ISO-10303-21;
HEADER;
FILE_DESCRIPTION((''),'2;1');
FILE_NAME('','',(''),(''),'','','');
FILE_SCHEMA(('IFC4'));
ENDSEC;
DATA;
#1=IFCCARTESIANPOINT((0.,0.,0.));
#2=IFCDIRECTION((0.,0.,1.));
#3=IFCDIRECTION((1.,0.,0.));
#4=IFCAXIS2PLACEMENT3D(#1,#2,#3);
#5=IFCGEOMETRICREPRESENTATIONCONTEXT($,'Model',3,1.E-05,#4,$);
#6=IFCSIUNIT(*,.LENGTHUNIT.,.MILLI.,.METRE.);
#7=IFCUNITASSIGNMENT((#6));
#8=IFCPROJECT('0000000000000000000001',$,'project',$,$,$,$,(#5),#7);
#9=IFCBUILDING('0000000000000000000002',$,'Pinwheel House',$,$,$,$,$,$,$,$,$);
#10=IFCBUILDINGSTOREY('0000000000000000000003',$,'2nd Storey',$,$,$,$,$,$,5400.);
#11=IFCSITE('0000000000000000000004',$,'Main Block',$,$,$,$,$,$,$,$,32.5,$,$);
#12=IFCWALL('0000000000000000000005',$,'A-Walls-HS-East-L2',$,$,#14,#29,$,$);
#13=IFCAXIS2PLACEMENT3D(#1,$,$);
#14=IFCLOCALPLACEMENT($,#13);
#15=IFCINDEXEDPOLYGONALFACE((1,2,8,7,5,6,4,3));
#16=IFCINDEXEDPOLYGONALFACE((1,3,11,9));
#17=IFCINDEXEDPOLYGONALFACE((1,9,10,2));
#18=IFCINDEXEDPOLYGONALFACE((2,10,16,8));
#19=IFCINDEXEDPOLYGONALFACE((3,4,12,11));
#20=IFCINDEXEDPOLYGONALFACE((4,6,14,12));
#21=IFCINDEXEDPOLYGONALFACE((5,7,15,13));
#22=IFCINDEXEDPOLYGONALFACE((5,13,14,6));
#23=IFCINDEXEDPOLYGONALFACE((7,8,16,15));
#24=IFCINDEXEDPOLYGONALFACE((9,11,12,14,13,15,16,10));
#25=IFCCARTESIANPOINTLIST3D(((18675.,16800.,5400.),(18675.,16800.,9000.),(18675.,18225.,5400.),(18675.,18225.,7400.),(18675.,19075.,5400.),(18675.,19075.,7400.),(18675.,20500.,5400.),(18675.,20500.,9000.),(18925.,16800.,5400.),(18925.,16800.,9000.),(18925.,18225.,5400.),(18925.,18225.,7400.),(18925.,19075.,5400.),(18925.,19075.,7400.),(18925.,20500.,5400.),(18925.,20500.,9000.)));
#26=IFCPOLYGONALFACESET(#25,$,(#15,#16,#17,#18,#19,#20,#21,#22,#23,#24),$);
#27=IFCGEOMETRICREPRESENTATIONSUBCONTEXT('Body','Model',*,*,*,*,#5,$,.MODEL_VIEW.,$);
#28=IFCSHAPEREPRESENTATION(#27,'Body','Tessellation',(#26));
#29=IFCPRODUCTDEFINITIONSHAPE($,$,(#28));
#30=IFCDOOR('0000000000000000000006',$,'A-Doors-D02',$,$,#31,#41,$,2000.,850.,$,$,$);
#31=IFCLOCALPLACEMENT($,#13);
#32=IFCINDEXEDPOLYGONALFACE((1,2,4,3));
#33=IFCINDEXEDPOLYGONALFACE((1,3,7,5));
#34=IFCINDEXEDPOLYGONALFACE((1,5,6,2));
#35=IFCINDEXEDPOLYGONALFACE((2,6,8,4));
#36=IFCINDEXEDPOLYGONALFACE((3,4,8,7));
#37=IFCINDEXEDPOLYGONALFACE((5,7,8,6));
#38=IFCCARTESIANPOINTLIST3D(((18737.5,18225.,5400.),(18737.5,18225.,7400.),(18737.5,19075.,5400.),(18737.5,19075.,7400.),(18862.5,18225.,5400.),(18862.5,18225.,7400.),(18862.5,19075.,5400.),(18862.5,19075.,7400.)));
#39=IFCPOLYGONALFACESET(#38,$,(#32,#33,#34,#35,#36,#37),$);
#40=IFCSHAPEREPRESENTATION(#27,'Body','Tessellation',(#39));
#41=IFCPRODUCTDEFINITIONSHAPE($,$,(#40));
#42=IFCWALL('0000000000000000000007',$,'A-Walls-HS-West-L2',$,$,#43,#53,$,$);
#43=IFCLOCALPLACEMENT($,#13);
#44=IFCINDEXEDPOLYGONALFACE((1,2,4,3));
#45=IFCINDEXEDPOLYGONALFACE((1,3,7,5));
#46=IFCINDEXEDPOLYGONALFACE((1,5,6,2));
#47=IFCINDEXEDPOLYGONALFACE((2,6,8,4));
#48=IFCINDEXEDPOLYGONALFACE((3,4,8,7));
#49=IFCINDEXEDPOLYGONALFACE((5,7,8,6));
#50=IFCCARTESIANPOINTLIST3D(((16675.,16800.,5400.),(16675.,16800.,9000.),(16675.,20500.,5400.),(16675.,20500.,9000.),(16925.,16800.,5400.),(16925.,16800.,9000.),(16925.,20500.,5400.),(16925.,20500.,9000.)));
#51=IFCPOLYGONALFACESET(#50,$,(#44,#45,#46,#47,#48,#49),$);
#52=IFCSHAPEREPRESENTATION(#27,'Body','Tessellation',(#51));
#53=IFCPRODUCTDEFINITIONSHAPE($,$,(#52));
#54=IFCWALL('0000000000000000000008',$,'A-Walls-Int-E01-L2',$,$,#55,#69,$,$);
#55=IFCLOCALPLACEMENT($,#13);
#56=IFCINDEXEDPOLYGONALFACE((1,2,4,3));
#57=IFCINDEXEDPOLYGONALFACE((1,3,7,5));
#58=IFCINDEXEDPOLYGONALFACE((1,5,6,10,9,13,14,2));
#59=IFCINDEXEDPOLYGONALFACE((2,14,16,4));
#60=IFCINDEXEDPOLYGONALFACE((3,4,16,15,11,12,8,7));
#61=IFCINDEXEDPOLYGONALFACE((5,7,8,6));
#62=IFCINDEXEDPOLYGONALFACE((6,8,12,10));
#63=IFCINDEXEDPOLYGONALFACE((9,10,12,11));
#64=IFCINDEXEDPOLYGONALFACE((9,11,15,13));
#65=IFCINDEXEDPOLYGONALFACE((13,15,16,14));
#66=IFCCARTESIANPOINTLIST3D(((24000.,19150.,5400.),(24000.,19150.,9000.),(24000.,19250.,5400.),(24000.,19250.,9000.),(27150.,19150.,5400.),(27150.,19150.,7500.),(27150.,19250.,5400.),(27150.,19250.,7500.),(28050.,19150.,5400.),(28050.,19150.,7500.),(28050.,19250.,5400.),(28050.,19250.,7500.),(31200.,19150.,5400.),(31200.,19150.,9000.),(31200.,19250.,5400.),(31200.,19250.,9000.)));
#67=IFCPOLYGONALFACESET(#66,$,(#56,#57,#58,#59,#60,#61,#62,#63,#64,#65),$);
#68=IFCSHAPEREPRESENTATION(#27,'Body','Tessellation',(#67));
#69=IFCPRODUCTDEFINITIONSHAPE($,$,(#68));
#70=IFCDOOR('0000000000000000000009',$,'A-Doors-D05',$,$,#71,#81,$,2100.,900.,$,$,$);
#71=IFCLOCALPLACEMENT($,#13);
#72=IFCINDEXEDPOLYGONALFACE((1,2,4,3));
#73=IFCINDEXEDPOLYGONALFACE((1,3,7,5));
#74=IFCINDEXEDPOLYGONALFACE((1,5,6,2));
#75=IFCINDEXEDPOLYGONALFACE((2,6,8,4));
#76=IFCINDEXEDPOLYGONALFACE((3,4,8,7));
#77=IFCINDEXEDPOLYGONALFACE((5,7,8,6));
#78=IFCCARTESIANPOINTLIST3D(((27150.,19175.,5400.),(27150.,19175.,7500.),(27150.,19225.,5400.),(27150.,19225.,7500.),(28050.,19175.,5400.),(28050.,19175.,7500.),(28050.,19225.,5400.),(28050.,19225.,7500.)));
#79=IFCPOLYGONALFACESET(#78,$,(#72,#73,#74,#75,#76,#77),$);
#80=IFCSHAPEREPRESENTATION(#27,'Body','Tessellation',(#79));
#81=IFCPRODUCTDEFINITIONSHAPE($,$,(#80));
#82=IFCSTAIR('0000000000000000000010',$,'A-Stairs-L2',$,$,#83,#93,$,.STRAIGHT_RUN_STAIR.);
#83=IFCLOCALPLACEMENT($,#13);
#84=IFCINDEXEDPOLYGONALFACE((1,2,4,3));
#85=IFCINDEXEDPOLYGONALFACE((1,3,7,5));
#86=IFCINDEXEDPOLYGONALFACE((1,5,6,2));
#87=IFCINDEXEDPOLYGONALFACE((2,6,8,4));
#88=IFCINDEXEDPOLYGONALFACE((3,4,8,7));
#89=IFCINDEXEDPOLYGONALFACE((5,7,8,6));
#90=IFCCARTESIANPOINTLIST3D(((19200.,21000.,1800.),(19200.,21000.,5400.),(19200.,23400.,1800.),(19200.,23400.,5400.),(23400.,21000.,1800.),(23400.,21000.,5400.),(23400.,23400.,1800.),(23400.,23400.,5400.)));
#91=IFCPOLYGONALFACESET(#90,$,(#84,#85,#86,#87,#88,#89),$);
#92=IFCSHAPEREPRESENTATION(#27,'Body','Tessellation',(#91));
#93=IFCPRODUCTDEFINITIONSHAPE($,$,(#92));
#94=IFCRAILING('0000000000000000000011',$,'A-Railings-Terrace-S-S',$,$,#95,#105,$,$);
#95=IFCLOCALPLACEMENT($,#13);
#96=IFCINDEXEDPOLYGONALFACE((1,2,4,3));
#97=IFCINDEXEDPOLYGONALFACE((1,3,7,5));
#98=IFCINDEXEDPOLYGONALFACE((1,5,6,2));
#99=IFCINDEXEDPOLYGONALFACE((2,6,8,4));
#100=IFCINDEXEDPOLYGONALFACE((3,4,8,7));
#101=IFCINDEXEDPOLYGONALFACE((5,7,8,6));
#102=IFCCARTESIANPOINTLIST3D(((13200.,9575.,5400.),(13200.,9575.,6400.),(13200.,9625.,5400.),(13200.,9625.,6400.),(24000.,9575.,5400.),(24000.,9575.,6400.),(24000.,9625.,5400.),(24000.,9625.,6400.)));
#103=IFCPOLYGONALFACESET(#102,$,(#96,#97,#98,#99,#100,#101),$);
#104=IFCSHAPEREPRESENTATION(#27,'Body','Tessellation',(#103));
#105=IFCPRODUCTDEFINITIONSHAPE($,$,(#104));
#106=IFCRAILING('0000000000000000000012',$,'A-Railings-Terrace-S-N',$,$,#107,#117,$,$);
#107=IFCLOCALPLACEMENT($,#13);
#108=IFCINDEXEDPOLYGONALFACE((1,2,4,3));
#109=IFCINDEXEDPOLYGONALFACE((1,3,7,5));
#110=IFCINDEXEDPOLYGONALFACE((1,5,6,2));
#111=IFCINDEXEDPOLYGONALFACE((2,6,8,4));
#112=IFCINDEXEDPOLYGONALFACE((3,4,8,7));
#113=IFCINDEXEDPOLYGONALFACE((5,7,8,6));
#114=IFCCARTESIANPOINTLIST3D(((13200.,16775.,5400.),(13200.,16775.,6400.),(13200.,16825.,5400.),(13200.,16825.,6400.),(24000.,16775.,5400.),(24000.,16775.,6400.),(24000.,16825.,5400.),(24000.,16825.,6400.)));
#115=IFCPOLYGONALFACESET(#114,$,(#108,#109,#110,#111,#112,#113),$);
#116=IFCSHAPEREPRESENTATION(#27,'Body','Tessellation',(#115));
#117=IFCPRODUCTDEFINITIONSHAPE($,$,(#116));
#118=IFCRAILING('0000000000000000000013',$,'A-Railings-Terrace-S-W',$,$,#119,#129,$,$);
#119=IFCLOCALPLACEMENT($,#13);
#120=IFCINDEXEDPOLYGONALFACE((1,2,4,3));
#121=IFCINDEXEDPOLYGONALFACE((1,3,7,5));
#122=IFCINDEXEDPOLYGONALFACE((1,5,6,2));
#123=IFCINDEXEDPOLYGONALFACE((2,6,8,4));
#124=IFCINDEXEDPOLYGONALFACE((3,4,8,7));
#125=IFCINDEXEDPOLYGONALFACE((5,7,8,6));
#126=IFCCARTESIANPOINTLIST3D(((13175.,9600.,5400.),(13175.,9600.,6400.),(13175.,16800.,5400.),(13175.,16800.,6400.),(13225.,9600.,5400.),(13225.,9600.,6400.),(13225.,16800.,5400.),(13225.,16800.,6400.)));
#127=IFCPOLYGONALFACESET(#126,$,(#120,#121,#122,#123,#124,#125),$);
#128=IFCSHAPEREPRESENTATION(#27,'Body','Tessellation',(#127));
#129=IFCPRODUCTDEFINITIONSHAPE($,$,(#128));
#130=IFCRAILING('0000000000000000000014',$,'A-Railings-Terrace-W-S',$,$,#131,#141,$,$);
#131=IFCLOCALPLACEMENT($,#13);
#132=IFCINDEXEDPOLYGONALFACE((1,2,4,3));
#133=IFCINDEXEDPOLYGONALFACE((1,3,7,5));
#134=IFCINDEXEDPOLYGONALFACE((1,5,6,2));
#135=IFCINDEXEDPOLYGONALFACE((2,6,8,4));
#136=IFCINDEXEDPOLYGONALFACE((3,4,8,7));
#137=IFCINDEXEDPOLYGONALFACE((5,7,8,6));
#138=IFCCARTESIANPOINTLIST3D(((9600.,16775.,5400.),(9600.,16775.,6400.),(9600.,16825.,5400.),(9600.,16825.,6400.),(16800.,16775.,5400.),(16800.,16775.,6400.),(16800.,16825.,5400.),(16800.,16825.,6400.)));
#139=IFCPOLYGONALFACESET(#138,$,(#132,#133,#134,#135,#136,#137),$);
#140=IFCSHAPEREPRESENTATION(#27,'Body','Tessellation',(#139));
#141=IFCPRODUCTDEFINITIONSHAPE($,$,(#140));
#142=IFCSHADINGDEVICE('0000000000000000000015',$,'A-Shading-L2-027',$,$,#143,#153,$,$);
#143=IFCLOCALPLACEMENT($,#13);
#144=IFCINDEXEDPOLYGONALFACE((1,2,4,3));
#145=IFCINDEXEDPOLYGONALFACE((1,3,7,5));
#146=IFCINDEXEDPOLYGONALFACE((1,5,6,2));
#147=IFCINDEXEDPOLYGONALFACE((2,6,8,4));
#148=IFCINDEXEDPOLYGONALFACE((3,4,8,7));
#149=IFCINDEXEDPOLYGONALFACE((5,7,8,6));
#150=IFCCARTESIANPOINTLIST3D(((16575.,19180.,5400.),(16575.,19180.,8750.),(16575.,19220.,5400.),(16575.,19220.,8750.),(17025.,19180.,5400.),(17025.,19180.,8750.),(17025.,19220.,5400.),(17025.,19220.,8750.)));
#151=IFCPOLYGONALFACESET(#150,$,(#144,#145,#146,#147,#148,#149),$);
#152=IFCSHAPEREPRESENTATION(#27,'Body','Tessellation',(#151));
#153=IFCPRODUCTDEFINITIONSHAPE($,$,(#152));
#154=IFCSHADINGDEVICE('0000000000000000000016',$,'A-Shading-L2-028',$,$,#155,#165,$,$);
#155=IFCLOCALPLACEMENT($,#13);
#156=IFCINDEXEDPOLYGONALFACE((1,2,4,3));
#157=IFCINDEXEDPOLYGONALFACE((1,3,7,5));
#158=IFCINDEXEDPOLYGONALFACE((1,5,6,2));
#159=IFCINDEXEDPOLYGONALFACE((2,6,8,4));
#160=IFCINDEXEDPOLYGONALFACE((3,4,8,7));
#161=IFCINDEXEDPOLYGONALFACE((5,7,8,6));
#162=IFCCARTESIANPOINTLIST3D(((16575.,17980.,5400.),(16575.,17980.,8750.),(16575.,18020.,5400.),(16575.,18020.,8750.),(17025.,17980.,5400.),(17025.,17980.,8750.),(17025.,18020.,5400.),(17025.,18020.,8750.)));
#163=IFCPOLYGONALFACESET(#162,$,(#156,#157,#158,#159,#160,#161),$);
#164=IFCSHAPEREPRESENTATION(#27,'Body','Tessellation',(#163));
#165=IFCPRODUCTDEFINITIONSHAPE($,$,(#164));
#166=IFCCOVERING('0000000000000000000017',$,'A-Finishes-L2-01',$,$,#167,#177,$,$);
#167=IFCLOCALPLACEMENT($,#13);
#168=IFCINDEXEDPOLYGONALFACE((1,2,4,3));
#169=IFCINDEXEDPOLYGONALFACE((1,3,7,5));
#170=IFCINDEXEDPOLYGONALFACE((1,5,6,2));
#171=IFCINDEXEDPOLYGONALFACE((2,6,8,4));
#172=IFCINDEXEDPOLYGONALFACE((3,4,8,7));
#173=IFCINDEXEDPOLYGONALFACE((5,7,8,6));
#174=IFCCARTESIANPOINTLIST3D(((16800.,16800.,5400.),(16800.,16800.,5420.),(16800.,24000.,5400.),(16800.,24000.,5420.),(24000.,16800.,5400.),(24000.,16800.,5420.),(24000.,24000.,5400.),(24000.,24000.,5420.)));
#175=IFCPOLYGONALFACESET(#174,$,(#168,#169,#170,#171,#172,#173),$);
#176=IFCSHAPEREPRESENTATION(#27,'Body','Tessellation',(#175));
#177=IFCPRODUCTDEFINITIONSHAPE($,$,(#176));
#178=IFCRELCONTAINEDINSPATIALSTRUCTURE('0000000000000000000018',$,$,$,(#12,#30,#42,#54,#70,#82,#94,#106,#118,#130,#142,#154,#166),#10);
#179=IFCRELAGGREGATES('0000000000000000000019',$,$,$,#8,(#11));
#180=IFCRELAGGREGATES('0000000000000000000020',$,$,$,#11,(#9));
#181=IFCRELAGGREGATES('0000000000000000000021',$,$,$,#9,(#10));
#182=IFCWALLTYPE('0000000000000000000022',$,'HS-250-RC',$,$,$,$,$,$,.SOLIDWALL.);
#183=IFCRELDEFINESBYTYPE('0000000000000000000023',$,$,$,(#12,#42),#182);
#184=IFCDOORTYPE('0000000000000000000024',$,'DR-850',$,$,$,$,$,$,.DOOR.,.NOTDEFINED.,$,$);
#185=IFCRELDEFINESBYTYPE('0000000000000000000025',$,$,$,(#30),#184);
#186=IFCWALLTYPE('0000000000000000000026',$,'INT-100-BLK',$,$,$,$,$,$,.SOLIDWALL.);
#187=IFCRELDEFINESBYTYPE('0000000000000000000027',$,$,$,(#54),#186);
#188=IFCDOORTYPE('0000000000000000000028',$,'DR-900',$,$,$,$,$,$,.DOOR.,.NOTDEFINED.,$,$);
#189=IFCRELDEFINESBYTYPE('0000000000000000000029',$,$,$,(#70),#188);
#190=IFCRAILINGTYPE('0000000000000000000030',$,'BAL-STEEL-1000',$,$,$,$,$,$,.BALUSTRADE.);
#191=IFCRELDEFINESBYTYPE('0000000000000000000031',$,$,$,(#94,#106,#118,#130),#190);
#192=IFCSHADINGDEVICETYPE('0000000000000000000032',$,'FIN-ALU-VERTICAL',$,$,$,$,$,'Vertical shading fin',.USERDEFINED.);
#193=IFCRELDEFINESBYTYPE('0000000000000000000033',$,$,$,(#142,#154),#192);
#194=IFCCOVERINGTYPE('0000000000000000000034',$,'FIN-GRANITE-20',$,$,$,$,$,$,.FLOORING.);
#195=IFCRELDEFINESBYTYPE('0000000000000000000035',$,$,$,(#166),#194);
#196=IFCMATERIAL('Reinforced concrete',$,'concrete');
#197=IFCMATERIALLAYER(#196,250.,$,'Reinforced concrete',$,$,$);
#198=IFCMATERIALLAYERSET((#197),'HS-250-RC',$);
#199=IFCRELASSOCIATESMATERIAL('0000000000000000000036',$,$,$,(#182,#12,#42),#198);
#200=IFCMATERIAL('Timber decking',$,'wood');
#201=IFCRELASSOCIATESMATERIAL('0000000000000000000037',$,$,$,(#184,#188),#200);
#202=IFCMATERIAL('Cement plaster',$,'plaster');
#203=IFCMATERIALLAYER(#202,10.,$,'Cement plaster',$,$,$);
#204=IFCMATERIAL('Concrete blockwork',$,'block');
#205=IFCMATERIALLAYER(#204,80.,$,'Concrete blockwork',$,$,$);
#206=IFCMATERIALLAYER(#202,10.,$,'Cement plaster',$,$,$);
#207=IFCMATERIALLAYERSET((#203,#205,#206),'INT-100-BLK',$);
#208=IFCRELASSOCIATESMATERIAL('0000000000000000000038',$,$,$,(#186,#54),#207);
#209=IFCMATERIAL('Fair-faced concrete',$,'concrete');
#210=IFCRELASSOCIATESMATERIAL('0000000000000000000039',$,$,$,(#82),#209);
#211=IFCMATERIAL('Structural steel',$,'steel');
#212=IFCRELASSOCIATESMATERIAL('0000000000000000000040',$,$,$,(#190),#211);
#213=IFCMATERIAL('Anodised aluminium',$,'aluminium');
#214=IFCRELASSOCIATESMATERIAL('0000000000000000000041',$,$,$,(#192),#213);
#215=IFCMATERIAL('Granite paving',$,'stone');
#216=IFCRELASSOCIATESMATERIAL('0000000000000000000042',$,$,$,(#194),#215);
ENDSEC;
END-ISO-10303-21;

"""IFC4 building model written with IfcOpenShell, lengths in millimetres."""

from ifc_helpers import new_model, si_unit, frame, origin_with_axes, place, context, subcontext, project, spatial, indexed_curve, outline, extrude, material, layer, layer_set, layer_usage, type_object, element, fill, save


model = new_model("IFC4")

# Units and contexts
model_context = context("Model", 3, precision=1e-05, world=origin_with_axes())
body_context = subcontext(model_context, "Body", "Model", "MODEL_VIEW")
ifc_project = project(units=[si_unit("LENGTHUNIT", "METRE", prefix="MILLI")], contexts=[model_context])

# Site, building, storey
site = spatial("IfcSite", under=ifc_project, Name="Main Block", RefElevation=32.5)
building = spatial("IfcBuilding", under=site, Name="Pinwheel House")
storey = spatial("IfcBuildingStorey", under=building, Name="2nd Storey", Elevation=5400.0)

# Shared definitions
ifc_material_1 = material(Name="Structural steel", Category="steel")

# Shared definitions
ifc_material_2 = material(Name="Anodised aluminium", Category="aluminium")

# Shared definitions
ifc_material_3 = material(Name="Reinforced concrete", Category="concrete")

# Shared definitions
ifc_layer_1 = layer(ifc_material_3, 250.0, Name="Reinforced concrete")
ifc_layer_set_1 = layer_set([ifc_layer_1], Name="HS-250-RC")
wall_type_1 = type_object("IfcWallType", Name="HS-250-RC", PredefinedType="SOLIDWALL", material=ifc_layer_set_1)

# Wall, opening, door
ifc_layer_usage_1 = layer_usage(ifc_layer_set_1, "AXIS2", "POSITIVE", 0.0)
wall_1_placement = place(None, frame((18925.0, 16800.0, 5400.0), z_axis=(0.0, 0.0, 1.0), x_axis=(0.0, 1.0, 0.0)))
wall_1 = element("IfcWall", 1, at=wall_1_placement, inside=storey, type_object=wall_type_1, material=ifc_layer_usage_1, Name="A-Walls-HS-East-L2", context=body_context, shape_type="SweptSolid", body=[
    extrude(outline(indexed_curve([(0.0, 0.0), (0.0, 250.0), (3700.0, 250.0), (3700.0, 0.0), (0.0, 0.0)], self_intersect=False)), origin_with_axes(), (0.0, 0.0, 1.0), 3600.0),
])
opening_1_placement = place(wall_1_placement, frame((1850.0, 125.0, 0.0), z_axis=(0.0, 0.0, 1.0), x_axis=(1.0, 0.0, 0.0)))
opening_1 = element("IfcOpeningElement", 2, at=opening_1_placement, cuts=wall_1, PredefinedType="OPENING", context=body_context, shape_type="SweptSolid", body=[
    extrude(outline(indexed_curve([(-425.0, -175.0), (425.0, -175.0), (425.0, 175.0), (-425.0, 175.0)])), None, (0.0, 0.0, 1.0), 2000.0),
])
ifc_material_4 = material(Name="Timber decking", Category="wood")
door_type_1 = type_object("IfcDoorType", Name="DR-850", OperationType="NOTDEFINED", PredefinedType="DOOR", material=ifc_material_4)
door_1_placement = place(None, frame((18800.0, 18650.0, 5400.0), z_axis=(0.0, 0.0, 1.0), x_axis=(0.0, 1.0, 0.0)))
door_1 = element("IfcDoor", 3, at=door_1_placement, inside=storey, type_object=door_type_1, Name="A-Doors-D02", OverallHeight=2000.0, OverallWidth=850.0, context=body_context, shape_type="SweptSolid", body=[
    extrude(outline(indexed_curve([(-425.0, -62.5), (425.0, -62.5), (425.0, 62.5), (-425.0, 62.5)])), None, (0.0, 0.0, 1.0), 2000.0),
])
fill(opening_1, door_1)

# Wall
ifc_layer_usage_2 = layer_usage(ifc_layer_set_1, "AXIS2", "POSITIVE", 0.0)
wall_2_placement = place(None, frame((16675.0, 20500.0, 5400.0), z_axis=(0.0, 0.0, 1.0), x_axis=(0.0, -1.0, 0.0)))
element("IfcWall", 4, at=wall_2_placement, inside=storey, type_object=wall_type_1, material=ifc_layer_usage_2, Name="A-Walls-HS-West-L2", context=body_context, shape_type="SweptSolid", body=[
    extrude(outline(indexed_curve([(0.0, 0.0), (0.0, 250.0), (3700.0, 250.0), (3700.0, 0.0), (0.0, 0.0)], self_intersect=False)), origin_with_axes(), (0.0, 0.0, 1.0), 3600.0),
])

# Wall, opening, door
ifc_material_5 = material(Name="Cement plaster", Category="plaster")
ifc_layer_2 = layer(ifc_material_5, 10.0, Name="Cement plaster")
ifc_material_6 = material(Name="Concrete blockwork", Category="block")
ifc_layer_3 = layer(ifc_material_6, 80.0, Name="Concrete blockwork")
ifc_layer_4 = layer(ifc_material_5, 10.0, Name="Cement plaster")
ifc_layer_set_2 = layer_set([ifc_layer_2, ifc_layer_3, ifc_layer_4], Name="INT-100-BLK")
ifc_layer_usage_3 = layer_usage(ifc_layer_set_2, "AXIS2", "POSITIVE", 0.0)
wall_type_2 = type_object("IfcWallType", Name="INT-100-BLK", PredefinedType="SOLIDWALL", material=ifc_layer_set_2)
wall_3_placement = place(None, frame((24000.0, 19150.0, 5400.0), z_axis=(0.0, 0.0, 1.0), x_axis=(1.0, 0.0, 0.0)))
wall_3 = element("IfcWall", 5, at=wall_3_placement, inside=storey, type_object=wall_type_2, material=ifc_layer_usage_3, Name="A-Walls-Int-E01-L2", context=body_context, shape_type="SweptSolid", body=[
    extrude(outline(indexed_curve([(0.0, 0.0), (0.0, 100.0), (7200.0, 100.0), (7200.0, 0.0), (0.0, 0.0)], self_intersect=False)), origin_with_axes(), (0.0, 0.0, 1.0), 3600.0),
])
opening_2_placement = place(wall_3_placement, frame((3600.0, 50.0, 0.0), z_axis=(0.0, 0.0, 1.0), x_axis=(1.0, 0.0, 0.0)))
opening_2 = element("IfcOpeningElement", 6, at=opening_2_placement, cuts=wall_3, PredefinedType="OPENING", context=body_context, shape_type="SweptSolid", body=[
    extrude(outline(indexed_curve([(-450.0, -100.0), (450.0, -100.0), (450.0, 100.0), (-450.0, 100.0)])), None, (0.0, 0.0, 1.0), 2100.0),
])
door_type_2 = type_object("IfcDoorType", Name="DR-900", OperationType="NOTDEFINED", PredefinedType="DOOR", material=ifc_material_4)
door_2_placement = place(None, frame((27600.0, 19200.0, 5400.0), z_axis=(0.0, 0.0, 1.0), x_axis=(1.0, 0.0, 0.0)))
door_2 = element("IfcDoor", 7, at=door_2_placement, inside=storey, type_object=door_type_2, Name="A-Doors-D05", OverallHeight=2100.0, OverallWidth=900.0, context=body_context, shape_type="SweptSolid", body=[
    extrude(outline(indexed_curve([(-450.0, -25.0), (450.0, -25.0), (450.0, 25.0), (-450.0, 25.0)])), None, (0.0, 0.0, 1.0), 2100.0),
])
fill(opening_2, door_2)

# Stair
ifc_material_7 = material(Name="Fair-faced concrete", Category="concrete")
stair_placement = place(None, frame((0.0, 0.0, 1800.0), z_axis=(0.0, 0.0, 1.0), x_axis=(1.0, 0.0, 0.0)))
element("IfcStair", 8, at=stair_placement, inside=storey, material=ifc_material_7, Name="A-Stairs-L2", PredefinedType="STRAIGHT_RUN_STAIR", context=body_context, shape_type="SweptSolid", body=[
    extrude(outline(indexed_curve([(19200.0, 21000.0), (23400.0, 21000.0), (23400.0, 23400.0), (19200.0, 23400.0)])), None, (0.0, 0.0, 1.0), 3600.0),
])

# Railings
railing_type = type_object("IfcRailingType", Name="BAL-STEEL-1000", PredefinedType="BALUSTRADE", material=ifc_material_1)
for number, where, z_axis, x_axis, name in (
    (9, (18600.0, 9600.0, 5400.0), (0.0, 0.0, 1.0), (1.0, 0.0, 0.0), "A-Railings-Terrace-S-S"),
    (10, (18600.0, 16800.0, 5400.0), (0.0, 0.0, 1.0), (-1.0, 0.0, 0.0), "A-Railings-Terrace-S-N"),
):
    element("IfcRailing", number, at=place(None, frame(where, z_axis=z_axis, x_axis=x_axis)), inside=storey, type_object=railing_type, Name=name, context=body_context, shape_type="SweptSolid", body=[
        extrude(outline(indexed_curve([(-5400.0, -25.0), (5400.0, -25.0), (5400.0, 25.0), (-5400.0, 25.0)])), None, (0.0, 0.0, 1.0), 1000.0),
    ])
for number, where, z_axis, x_axis, name in (
    (11, (13200.0, 13200.0, 5400.0), (0.0, 0.0, 1.0), (0.0, -1.0, 0.0), "A-Railings-Terrace-S-W"),
    (12, (13200.0, 16800.0, 5400.0), (0.0, 0.0, 1.0), (1.0, 0.0, 0.0), "A-Railings-Terrace-W-S"),
):
    element("IfcRailing", number, at=place(None, frame(where, z_axis=z_axis, x_axis=x_axis)), inside=storey, type_object=railing_type, Name=name, context=body_context, shape_type="SweptSolid", body=[
        extrude(outline(indexed_curve([(-3600.0, -25.0), (3600.0, -25.0), (3600.0, 25.0), (-3600.0, 25.0)])), None, (0.0, 0.0, 1.0), 1000.0),
    ])

# Shading devices
shading_device_type = type_object("IfcShadingDeviceType", Name="FIN-ALU-VERTICAL", ElementType="Vertical shading fin", PredefinedType="USERDEFINED", material=ifc_material_2)
for number, where, z_axis, x_axis, name in (
    (13, (16800.0, 19200.0, 5400.0), (0.0, 0.0, 1.0), (0.0, -1.0, 0.0), "A-Shading-L2-027"),
    (14, (16800.0, 18000.0, 5400.0), (0.0, 0.0, 1.0), (0.0, -1.0, 0.0), "A-Shading-L2-028"),
):
    element("IfcShadingDevice", number, at=place(None, frame(where, z_axis=z_axis, x_axis=x_axis)), inside=storey, type_object=shading_device_type, Name=name, context=body_context, shape_type="SweptSolid", body=[
        extrude(outline(indexed_curve([(-20.0, -225.0), (20.0, -225.0), (20.0, 225.0), (-20.0, 225.0)])), None, (0.0, 0.0, 1.0), 3350.0),
    ])

# Covering
ifc_material_8 = material(Name="Granite paving", Category="stone")
covering_type = type_object("IfcCoveringType", Name="FIN-GRANITE-20", PredefinedType="FLOORING", material=ifc_material_8)
covering_1_placement = place(None, frame((0.0, 0.0, 5400.0), z_axis=(0.0, 0.0, 1.0), x_axis=(1.0, 0.0, 0.0)))
element("IfcCovering", 15, at=covering_1_placement, inside=storey, type_object=covering_type, Name="A-Finishes-L2-01", context=body_context, shape_type="SweptSolid", body=[
    extrude(outline(indexed_curve([(16800.0, 16800.0), (24000.0, 16800.0), (24000.0, 24000.0), (16800.0, 24000.0)])), None, (0.0, 0.0, 1.0), 20.0),
])

save(model, "model.ifc")
